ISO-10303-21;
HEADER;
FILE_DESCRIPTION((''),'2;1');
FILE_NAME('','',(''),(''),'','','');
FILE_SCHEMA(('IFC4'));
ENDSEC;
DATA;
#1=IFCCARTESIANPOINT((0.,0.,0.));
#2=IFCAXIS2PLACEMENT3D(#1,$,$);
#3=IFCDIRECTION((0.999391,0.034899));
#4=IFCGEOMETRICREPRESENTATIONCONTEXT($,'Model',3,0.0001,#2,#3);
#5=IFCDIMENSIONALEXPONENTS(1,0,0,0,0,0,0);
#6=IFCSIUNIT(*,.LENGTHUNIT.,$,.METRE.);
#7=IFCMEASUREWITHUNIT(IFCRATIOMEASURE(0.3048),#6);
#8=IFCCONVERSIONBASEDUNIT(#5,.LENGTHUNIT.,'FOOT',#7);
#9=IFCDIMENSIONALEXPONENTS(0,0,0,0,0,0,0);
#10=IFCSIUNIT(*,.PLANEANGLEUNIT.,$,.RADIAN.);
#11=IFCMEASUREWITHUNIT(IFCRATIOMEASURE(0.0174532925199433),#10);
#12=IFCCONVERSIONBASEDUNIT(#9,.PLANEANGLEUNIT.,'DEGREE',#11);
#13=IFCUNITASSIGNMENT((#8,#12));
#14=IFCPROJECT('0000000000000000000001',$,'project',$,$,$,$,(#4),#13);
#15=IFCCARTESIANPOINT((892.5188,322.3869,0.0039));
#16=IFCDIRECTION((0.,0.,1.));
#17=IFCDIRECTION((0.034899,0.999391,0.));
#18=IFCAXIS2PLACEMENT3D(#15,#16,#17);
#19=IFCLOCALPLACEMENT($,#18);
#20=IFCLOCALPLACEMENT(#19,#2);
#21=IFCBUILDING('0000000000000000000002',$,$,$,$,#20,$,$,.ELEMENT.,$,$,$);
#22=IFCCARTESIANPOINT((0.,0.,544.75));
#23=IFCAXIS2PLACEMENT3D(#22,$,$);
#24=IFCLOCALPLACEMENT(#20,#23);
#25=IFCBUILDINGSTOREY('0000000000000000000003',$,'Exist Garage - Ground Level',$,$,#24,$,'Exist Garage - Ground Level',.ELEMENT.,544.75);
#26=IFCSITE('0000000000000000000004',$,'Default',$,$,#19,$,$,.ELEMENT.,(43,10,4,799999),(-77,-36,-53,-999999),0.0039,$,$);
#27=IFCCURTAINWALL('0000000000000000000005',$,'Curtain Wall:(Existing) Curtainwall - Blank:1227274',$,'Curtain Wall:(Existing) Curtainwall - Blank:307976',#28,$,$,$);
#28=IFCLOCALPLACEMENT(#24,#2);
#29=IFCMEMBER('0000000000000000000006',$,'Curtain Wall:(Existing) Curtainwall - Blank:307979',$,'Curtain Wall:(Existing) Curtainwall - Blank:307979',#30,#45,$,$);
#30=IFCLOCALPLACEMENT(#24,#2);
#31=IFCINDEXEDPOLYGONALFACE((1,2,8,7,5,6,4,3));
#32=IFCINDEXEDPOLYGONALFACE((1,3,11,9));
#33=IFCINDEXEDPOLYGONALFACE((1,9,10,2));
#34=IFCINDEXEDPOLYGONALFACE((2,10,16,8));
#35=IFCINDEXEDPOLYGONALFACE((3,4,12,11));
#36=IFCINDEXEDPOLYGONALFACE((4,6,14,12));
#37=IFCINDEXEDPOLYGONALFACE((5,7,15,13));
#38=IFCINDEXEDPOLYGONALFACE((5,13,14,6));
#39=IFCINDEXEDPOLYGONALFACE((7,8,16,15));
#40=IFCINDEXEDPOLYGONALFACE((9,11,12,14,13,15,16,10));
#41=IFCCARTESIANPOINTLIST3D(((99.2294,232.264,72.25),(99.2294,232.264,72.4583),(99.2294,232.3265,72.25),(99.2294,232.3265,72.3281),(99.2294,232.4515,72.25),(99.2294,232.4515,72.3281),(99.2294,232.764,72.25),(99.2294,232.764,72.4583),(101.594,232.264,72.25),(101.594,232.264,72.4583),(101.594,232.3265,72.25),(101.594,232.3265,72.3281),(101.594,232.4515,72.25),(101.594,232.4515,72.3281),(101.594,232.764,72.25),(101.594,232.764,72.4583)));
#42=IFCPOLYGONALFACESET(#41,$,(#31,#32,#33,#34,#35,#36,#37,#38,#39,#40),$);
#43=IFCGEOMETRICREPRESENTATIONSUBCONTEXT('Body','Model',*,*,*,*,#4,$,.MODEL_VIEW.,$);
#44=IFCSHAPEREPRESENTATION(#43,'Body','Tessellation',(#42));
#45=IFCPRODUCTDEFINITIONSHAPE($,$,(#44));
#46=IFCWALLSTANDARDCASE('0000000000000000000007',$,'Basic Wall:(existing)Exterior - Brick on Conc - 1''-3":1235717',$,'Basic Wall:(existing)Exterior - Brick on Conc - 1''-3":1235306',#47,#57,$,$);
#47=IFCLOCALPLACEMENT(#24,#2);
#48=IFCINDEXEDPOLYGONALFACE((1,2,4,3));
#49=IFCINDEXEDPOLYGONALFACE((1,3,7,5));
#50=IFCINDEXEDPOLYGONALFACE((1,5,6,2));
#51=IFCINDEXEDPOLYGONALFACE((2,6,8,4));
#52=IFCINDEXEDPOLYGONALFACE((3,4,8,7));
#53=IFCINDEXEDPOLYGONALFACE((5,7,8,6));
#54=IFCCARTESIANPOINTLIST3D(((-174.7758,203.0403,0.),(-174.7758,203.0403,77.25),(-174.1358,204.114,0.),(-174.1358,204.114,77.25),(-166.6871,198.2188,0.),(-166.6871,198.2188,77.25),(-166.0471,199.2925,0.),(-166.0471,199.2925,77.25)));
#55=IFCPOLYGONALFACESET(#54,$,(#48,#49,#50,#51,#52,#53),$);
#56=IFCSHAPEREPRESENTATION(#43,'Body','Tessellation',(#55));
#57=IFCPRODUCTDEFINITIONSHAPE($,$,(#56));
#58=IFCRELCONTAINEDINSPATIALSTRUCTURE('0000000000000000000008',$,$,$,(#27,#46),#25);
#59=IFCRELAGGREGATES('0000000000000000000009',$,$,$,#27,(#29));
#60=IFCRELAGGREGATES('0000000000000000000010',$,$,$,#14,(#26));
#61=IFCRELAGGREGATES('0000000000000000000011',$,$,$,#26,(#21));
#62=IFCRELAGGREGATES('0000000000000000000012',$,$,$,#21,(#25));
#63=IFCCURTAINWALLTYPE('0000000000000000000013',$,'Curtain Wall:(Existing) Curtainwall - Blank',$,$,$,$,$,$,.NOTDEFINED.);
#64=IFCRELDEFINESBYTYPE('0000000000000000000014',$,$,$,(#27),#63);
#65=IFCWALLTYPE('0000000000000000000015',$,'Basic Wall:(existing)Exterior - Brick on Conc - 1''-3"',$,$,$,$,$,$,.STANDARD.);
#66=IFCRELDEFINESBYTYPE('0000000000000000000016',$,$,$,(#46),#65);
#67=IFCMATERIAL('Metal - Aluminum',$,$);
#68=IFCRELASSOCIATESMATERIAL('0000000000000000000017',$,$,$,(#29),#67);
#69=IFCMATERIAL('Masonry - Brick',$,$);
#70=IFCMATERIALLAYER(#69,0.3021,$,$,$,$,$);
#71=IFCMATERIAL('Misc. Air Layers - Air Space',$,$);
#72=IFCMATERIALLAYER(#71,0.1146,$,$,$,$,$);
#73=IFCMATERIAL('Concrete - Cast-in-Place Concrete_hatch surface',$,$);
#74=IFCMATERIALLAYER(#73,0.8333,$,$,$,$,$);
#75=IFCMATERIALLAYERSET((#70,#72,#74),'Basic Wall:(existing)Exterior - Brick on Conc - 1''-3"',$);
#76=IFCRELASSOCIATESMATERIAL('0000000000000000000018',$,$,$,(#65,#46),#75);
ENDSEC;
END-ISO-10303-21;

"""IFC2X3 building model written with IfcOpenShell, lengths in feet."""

from ifc_helpers import new_model, entity, si_unit, converted_unit, direction, frame, frame_2d, origin, place, context, subcontext, project, spatial, polyline, rectangle, outline, extrude, material, layer, layer_set, layer_usage, type_object, element, aggregate, save


model = new_model("IFC2X3")

# Units and contexts
model_context = context("Model", 3, precision=0.0001, world=origin(), true_north=direction((0.999391, 0.034899)))
body_context = subcontext(model_context, "Body", "Model", "MODEL_VIEW")
ifc_project = project(units=[converted_unit("LENGTHUNIT", "FOOT", entity("IfcRatioMeasure", 0.3048), si_unit("LENGTHUNIT", "METRE"), dimensions=[1, 0, 0, 0, 0, 0, 0]), converted_unit("PLANEANGLEUNIT", "DEGREE", entity("IfcRatioMeasure", 0.0174532925199433), si_unit("PLANEANGLEUNIT", "RADIAN"), dimensions=[0, 0, 0, 0, 0, 0, 0])], contexts=[model_context])

# Site, building, storey
site_placement = place(None, frame((892.5188, 322.3869, 0.0039), z_axis=(0.0, 0.0, 1.0), x_axis=(0.034899, 0.999391, 0.0)))
site = spatial("IfcSite", under=ifc_project, at=site_placement, Name="Default", CompositionType="ELEMENT", RefLatitude=(43, 10, 4, 799999), RefLongitude=(-77, -36, -53, -999999), RefElevation=0.0039)
building_placement = place(site_placement, origin())
building = spatial("IfcBuilding", under=site, at=building_placement, CompositionType="ELEMENT")
storey_placement = place(building_placement, frame((0.0, 0.0, 544.75)))
storey = spatial("IfcBuildingStorey", under=building, at=storey_placement, Name="Exist Garage - Ground Level", LongName="Exist Garage - Ground Level", CompositionType="ELEMENT", Elevation=544.75)

# Curtain wall, member
curtain_wall_type = type_object("IfcCurtainWallType", Name="Curtain Wall:(Existing) Curtainwall - Blank", PredefinedType="NOTDEFINED")
ifc_material_1 = material(Name="Metal - Aluminum")
curtain_wall_1_placement = place(storey_placement, frame((0.0, 0.0, -544.75)))
curtain_wall_1 = element("IfcCurtainWall", 1, at=curtain_wall_1_placement, inside=storey, type_object=curtain_wall_type, Name="Curtain Wall:(Existing) Curtainwall - Blank:1227274", ObjectType="Curtain Wall:(Existing) Curtainwall - Blank:307976")
member_1_placement = place(curtain_wall_1_placement, frame((0.0, 0.0, 544.75)))
member_1 = element("IfcMember", 2, at=member_1_placement, material=ifc_material_1, Name="Curtain Wall:(Existing) Curtainwall - Blank:307979", ObjectType="Curtain Wall:(Existing) Curtainwall - Blank:307979", context=body_context, shape_type="SweptSolid", body=[
    extrude(outline(polyline([(-0.1367, -0.1875), (0.0716, -0.1875), (0.0716, -0.125), (-0.0065, -0.125), (-0.0065, 0.0), (0.0716, 0.0), (0.0716, 0.3125), (-0.1367, 0.3125), (-0.1367, -0.1875)])), frame((99.2294, 232.4515, 72.3216), z_axis=(1.0, 0.0, 0.0), x_axis=(0.0, 0.0, -1.0)), (0.0, 0.0, 1.0), 2.3646),
])
aggregate(curtain_wall_1, [member_1])

# Wall
ifc_material_2 = material(Name="Masonry - Brick")
ifc_layer_1 = layer(ifc_material_2, 0.3021)
ifc_material_3 = material(Name="Misc. Air Layers - Air Space")
ifc_layer_2 = layer(ifc_material_3, 0.1146)
ifc_material_4 = material(Name="Concrete - Cast-in-Place Concrete_hatch surface")
ifc_layer_3 = layer(ifc_material_4, 0.8333)
ifc_layer_set = layer_set([ifc_layer_1, ifc_layer_2, ifc_layer_3], Name="Basic Wall:(existing)Exterior - Brick on Conc - 1'-3\"")
ifc_layer_usage = layer_usage(ifc_layer_set, "AXIS2", "NEGATIVE", 0.625)
wall_type = type_object("IfcWallType", Name="Basic Wall:(existing)Exterior - Brick on Conc - 1'-3\"", PredefinedType="STANDARD", material=ifc_layer_set)
wall_placement = place(storey_placement, frame((-166.3671, 198.7556, 0.0), z_axis=(0.0, 0.0, 1.0), x_axis=(-0.858972, 0.512022, 0.0)))
element("IfcWallStandardCase", 3, at=wall_placement, inside=storey, type_object=wall_type, material=ifc_layer_usage, Name="Basic Wall:(existing)Exterior - Brick on Conc - 1'-3\":1235717", ObjectType="Basic Wall:(existing)Exterior - Brick on Conc - 1'-3\":1235306", context=body_context, shape_type="SweptSolid", body=[
    extrude(rectangle(XDim=9.4167, YDim=1.25, at=frame_2d((4.7083, 0.0), x_axis=(-1.0, 0.0))), origin(), (0.0, 0.0, 1.0), 77.25),
])

save(model, "model.ifc")
